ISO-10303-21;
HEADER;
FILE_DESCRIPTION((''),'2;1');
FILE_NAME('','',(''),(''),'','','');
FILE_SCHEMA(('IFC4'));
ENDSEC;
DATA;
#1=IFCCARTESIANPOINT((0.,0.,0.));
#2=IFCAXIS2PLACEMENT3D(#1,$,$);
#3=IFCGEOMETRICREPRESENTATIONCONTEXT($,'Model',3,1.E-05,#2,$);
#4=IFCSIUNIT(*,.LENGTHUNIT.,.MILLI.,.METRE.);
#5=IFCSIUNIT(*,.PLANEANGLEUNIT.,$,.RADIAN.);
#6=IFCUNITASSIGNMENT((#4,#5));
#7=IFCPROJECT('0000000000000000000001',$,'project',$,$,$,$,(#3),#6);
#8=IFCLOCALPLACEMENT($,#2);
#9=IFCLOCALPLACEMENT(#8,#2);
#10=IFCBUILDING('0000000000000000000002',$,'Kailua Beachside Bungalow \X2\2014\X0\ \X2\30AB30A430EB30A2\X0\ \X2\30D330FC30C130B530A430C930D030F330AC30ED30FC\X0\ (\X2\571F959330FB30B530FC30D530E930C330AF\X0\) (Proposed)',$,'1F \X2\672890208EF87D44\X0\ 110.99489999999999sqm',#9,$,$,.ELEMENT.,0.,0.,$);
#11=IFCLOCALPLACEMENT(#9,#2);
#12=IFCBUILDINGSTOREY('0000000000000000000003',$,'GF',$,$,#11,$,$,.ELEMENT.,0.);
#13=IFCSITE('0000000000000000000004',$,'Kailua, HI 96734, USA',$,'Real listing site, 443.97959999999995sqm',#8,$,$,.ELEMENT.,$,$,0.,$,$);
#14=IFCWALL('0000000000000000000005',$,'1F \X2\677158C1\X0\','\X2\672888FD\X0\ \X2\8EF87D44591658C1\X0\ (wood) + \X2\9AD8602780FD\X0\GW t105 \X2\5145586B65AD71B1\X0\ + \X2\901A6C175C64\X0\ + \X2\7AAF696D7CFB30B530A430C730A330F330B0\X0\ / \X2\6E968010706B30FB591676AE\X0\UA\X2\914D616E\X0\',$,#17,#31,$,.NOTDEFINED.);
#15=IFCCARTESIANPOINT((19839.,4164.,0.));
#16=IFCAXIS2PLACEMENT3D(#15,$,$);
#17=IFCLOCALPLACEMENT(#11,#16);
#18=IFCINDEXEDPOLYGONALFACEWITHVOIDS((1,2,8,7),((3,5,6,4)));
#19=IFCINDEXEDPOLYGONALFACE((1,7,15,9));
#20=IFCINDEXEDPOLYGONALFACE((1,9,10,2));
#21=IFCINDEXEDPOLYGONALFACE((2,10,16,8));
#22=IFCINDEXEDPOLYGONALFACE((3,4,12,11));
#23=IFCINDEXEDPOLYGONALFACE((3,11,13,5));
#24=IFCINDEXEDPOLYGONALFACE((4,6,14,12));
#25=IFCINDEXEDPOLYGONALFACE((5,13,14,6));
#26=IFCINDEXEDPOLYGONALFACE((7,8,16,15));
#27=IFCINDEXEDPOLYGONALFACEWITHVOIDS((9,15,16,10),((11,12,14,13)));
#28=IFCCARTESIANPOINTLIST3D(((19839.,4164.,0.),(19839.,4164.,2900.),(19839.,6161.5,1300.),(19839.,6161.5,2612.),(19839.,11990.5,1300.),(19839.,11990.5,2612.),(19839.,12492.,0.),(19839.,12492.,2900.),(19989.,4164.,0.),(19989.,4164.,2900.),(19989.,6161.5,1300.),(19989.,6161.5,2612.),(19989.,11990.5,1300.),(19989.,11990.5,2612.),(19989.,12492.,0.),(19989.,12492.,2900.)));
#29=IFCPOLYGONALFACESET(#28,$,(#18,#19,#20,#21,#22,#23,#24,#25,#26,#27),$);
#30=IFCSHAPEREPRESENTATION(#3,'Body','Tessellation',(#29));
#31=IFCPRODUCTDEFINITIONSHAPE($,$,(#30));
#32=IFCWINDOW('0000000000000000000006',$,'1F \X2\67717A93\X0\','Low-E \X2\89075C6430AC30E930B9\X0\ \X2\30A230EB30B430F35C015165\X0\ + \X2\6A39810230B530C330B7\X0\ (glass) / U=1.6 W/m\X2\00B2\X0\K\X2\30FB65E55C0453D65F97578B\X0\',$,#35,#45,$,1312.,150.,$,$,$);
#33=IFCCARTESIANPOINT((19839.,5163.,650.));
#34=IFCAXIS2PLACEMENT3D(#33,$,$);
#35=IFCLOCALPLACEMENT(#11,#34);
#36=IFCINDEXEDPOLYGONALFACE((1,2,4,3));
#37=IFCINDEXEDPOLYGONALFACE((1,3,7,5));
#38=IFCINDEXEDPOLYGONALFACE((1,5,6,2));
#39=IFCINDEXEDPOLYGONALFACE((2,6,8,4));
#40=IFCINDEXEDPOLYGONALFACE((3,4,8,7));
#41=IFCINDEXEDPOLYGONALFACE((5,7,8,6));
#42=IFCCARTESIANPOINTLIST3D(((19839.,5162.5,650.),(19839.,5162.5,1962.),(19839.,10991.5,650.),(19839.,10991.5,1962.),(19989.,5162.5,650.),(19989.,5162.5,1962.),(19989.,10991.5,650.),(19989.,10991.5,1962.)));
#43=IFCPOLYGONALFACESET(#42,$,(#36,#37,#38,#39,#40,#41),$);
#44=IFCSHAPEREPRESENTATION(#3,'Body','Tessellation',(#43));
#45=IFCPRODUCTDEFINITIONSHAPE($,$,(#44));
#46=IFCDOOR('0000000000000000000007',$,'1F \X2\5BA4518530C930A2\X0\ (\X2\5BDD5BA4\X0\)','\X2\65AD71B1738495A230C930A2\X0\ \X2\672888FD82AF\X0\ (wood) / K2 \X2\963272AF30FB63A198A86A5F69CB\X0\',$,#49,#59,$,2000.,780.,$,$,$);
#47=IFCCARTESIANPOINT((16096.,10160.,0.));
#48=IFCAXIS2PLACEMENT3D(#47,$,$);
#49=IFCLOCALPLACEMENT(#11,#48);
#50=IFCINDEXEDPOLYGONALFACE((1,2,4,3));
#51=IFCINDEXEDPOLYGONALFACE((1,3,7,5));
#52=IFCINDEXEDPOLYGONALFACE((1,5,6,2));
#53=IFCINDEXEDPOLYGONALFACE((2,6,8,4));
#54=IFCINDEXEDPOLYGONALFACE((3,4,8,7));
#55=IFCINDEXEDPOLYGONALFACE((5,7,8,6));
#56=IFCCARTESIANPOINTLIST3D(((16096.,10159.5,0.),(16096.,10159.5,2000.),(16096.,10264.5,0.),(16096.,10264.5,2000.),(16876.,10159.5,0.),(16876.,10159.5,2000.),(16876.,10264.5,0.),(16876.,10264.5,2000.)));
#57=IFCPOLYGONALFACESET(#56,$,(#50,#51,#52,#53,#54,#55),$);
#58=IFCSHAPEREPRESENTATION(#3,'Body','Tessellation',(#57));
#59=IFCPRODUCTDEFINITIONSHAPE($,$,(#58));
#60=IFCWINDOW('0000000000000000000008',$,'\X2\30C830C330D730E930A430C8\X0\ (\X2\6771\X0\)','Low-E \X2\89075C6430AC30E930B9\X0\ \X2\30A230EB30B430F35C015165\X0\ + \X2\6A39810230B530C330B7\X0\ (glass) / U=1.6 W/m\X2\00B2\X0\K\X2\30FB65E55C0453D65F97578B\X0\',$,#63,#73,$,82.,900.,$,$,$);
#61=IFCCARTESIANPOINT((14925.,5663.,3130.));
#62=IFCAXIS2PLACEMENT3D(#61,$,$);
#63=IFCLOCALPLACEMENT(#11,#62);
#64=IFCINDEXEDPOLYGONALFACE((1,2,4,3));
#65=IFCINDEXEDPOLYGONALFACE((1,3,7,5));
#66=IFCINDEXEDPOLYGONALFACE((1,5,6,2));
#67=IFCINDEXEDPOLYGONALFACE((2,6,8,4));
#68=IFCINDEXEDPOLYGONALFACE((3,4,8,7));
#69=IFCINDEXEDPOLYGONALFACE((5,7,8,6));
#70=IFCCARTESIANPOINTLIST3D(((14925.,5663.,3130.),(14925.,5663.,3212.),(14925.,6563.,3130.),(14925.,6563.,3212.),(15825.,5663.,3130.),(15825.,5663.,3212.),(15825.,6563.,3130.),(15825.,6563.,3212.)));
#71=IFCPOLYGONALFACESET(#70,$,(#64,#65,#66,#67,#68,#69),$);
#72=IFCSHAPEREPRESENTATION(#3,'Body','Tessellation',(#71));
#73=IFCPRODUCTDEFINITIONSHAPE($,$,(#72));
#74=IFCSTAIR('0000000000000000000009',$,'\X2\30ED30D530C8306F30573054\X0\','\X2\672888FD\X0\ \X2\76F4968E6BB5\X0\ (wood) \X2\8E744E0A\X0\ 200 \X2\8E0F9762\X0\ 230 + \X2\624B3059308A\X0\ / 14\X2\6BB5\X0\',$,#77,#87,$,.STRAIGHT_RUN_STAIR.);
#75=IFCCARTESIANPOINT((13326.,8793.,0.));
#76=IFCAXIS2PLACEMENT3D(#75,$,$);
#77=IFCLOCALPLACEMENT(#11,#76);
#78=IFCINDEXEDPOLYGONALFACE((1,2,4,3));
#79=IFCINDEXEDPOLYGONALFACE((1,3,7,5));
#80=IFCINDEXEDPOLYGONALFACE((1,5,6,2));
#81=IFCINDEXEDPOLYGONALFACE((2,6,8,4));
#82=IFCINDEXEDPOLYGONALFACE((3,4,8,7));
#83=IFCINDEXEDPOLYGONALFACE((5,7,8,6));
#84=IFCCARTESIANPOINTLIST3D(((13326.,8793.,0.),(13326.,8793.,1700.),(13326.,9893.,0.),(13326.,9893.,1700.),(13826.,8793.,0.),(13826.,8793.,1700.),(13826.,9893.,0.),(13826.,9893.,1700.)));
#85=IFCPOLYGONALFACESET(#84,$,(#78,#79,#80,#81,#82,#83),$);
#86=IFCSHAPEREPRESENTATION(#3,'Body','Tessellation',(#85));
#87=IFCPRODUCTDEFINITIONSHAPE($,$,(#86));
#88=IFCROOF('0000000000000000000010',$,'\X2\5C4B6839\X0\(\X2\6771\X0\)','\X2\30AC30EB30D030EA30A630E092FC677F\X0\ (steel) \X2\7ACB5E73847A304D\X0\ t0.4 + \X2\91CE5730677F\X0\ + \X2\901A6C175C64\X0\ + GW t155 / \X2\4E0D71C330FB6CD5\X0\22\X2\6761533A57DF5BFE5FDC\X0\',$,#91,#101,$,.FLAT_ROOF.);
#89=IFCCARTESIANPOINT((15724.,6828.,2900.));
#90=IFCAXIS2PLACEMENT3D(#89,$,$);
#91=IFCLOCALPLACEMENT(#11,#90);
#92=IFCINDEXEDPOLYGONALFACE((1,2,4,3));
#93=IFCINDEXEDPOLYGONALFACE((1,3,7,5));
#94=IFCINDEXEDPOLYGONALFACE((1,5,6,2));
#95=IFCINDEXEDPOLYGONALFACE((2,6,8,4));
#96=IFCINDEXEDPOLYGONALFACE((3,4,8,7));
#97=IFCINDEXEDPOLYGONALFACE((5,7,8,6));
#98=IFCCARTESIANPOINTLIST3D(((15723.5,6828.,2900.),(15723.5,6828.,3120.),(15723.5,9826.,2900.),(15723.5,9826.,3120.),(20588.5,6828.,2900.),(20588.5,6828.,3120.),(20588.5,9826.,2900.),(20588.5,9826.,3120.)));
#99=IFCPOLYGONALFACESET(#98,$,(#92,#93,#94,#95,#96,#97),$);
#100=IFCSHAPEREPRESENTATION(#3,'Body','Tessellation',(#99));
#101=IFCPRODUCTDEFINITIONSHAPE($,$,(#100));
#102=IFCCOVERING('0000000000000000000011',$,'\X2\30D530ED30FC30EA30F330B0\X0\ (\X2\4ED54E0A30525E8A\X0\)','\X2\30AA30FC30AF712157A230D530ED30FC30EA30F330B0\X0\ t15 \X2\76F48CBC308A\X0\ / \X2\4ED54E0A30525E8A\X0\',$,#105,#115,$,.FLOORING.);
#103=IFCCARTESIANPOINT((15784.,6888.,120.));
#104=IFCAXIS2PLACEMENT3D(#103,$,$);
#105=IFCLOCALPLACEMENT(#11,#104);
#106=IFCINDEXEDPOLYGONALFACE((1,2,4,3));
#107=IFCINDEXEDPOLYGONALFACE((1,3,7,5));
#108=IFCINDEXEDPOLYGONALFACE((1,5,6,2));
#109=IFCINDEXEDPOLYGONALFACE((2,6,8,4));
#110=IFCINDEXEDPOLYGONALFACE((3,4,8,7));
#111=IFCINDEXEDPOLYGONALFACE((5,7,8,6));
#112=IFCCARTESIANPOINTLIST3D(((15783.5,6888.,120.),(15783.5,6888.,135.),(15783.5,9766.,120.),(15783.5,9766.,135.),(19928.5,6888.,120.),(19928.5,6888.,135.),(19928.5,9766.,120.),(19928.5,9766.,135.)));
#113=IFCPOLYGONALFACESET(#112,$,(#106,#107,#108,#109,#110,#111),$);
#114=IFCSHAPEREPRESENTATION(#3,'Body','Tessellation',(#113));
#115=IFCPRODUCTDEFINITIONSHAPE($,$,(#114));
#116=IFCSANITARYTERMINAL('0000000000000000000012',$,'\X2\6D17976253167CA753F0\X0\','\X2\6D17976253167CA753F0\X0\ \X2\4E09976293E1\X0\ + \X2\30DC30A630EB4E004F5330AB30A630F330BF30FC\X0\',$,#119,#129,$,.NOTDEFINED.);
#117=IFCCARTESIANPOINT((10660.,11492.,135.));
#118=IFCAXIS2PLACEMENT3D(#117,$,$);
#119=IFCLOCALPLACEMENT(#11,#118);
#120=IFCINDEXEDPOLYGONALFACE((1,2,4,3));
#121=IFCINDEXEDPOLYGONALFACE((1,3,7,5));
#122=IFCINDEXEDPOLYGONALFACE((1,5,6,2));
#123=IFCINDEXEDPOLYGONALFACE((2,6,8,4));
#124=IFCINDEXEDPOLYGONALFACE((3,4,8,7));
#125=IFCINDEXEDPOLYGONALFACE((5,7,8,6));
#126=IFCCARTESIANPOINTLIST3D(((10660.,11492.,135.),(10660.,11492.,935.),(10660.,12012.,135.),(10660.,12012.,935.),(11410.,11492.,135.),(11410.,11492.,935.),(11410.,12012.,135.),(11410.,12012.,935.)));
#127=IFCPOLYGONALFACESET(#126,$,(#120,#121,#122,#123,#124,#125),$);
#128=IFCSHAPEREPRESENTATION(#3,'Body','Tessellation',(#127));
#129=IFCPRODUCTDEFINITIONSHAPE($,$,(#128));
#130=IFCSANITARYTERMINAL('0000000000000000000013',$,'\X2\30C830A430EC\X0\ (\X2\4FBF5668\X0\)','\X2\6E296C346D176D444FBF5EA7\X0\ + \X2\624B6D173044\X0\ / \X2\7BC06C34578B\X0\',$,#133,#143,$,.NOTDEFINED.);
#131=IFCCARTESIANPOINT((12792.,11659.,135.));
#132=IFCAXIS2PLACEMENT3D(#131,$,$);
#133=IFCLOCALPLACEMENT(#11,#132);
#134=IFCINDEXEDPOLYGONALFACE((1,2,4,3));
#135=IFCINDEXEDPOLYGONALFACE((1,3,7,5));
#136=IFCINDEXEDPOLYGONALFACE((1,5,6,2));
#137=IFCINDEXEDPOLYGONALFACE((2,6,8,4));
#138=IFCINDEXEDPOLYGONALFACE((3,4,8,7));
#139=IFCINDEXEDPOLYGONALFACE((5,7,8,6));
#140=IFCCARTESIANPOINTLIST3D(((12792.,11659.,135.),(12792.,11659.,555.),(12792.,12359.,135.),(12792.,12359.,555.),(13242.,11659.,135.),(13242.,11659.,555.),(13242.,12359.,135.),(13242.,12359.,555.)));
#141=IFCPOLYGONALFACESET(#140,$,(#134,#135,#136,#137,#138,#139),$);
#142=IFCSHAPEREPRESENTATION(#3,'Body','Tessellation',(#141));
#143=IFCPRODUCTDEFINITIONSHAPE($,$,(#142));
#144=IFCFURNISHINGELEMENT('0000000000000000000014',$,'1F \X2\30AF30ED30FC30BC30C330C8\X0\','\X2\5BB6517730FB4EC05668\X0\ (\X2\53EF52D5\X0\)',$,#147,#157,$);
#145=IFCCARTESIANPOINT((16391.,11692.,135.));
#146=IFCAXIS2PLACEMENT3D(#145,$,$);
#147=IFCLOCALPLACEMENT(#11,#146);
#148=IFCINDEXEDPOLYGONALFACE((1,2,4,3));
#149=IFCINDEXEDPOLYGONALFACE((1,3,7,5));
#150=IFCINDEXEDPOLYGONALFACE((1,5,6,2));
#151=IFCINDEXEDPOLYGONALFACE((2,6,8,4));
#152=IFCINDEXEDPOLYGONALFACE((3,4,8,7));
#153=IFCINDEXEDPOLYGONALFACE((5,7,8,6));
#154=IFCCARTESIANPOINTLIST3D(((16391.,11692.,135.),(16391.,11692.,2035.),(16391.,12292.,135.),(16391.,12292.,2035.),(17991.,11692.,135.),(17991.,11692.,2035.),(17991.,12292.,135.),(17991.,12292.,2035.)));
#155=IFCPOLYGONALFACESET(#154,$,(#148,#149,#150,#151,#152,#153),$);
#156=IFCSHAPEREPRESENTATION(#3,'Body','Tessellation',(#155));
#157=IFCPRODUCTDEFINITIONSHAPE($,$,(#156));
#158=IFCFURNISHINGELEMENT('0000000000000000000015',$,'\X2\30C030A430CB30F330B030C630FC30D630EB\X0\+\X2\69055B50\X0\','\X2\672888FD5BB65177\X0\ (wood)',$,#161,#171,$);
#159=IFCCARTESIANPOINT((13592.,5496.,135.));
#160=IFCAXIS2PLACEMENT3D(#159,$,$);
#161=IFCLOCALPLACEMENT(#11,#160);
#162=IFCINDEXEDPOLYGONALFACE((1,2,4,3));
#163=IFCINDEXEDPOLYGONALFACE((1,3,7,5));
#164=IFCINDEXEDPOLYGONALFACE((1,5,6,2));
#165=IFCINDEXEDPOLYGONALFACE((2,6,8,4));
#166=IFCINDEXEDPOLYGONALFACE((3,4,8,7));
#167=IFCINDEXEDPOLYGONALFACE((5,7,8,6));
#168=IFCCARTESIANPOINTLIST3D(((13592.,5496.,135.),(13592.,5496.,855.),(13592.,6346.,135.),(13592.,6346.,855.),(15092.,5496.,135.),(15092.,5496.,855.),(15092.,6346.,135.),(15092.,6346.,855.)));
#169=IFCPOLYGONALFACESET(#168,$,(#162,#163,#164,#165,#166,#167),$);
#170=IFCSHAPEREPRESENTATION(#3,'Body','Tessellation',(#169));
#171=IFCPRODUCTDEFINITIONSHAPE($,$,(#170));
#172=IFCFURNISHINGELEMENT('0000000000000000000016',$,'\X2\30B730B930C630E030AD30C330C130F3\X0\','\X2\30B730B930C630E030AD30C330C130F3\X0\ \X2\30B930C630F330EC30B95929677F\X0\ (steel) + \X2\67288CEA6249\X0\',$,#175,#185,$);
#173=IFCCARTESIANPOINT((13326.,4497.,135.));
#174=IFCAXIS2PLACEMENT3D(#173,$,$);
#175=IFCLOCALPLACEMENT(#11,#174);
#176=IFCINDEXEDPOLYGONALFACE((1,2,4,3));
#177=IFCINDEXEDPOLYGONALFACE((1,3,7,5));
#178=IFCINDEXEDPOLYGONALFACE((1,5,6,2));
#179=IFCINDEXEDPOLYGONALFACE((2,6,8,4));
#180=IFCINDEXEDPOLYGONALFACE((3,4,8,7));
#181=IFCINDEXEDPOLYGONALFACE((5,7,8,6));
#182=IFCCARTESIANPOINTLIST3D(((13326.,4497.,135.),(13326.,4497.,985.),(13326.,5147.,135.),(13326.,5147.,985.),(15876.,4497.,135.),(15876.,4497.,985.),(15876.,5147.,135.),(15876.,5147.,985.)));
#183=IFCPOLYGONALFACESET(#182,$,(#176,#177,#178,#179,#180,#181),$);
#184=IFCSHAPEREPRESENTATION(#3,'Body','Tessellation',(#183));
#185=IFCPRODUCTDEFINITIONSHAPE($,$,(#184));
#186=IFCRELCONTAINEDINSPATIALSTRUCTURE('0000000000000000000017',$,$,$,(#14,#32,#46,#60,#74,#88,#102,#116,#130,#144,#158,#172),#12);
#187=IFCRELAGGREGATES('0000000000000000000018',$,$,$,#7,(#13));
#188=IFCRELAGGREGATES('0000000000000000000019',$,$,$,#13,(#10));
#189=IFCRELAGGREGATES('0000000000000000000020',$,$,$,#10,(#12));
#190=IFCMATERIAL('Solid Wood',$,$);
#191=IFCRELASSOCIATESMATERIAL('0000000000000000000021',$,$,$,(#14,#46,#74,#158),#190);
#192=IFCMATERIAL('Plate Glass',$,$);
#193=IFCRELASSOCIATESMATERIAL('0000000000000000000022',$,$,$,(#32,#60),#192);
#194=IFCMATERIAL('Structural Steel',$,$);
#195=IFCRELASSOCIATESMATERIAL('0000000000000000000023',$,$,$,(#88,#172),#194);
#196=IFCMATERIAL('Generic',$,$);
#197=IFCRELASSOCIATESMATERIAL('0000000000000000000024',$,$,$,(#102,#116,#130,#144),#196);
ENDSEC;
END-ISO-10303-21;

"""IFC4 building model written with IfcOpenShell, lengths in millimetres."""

from ifc_helpers import new_model, si_unit, frame, frame_2d, origin, place, context, project, spatial, rectangle, extrude, material, element, fill, save


model = new_model("IFC4")

# Units and contexts
model_context = context("Model", 3, precision=1e-05, world=origin())
ifc_project = project(units=[si_unit("LENGTHUNIT", "METRE", prefix="MILLI"), si_unit("PLANEANGLEUNIT", "RADIAN")], contexts=[model_context])

# Site, building, storey
site_placement = place(None, origin())
site = spatial("IfcSite", under=ifc_project, at=site_placement, Name="Kailua, HI 96734, USA", ObjectType="Real listing site, 443.97959999999995sqm", CompositionType="ELEMENT", RefElevation=0.0)
building_placement = place(site_placement, origin())
building = spatial("IfcBuilding", under=site, at=building_placement, Name="Kailua Beachside Bungalow — カイルア ビーチサイドバンガロー (土間・サーフラック) (Proposed)", ObjectType="1F 木造軸組 110.99489999999999sqm", CompositionType="ELEMENT", ElevationOfRefHeight=0.0, ElevationOfTerrain=0.0)
storey_placement = place(building_placement, origin())
storey = spatial("IfcBuildingStorey", under=building, at=storey_placement, Name="GF", CompositionType="ELEMENT", Elevation=0.0)

# Shared definitions
ifc_material_1 = material(Name="Solid Wood")

# Wall, opening, window
wall_1_placement = place(storey_placement, frame((19839.0, 4164.0, 0.0)))
wall_1 = element("IfcWall", 1, at=wall_1_placement, inside=storey, material=ifc_material_1, Name="1F 東壁", Description="木製 軸組外壁 (wood) + 高性能GW t105 充填断熱 + 通気層 + 窯業系サイディング / 準耐火・外皮UA配慮", PredefinedType="NOTDEFINED", context=model_context, shape_type="SweptSolid", body=[
    extrude(rectangle(XDim=150.0, YDim=8328.0, at=frame_2d((75.0, 4164.0))), frame((19839.0, 4164.0, 0.0)), (0.0, 0.0, 1.0), 2900.0),
])
opening_1_placement = place(storey_placement, frame((19839.0, 5163.0, 650.0)))
opening_1 = element("IfcOpeningElement", 2, at=opening_1_placement, cuts=wall_1, PredefinedType="NOTDEFINED", context=model_context, shape_type="SweptSolid", body=[
    extrude(rectangle(XDim=150.0, YDim=5829.0, at=frame_2d((75.0, 2914.0))), frame((19839.0, 5163.0, 650.0)), (0.0, 0.0, 1.0), 1312.0),
])
ifc_material_2 = material(Name="Plate Glass")
window_1_placement = place(storey_placement, frame((19839.0, 5163.0, 650.0)))
window_1 = element("IfcWindow", 3, at=window_1_placement, inside=storey, material=ifc_material_2, Name="1F 東窓", Description="Low-E 複層ガラス アルゴン封入 + 樹脂サッシ (glass) / U=1.6 W/m²K・日射取得型", OverallHeight=1312.0, OverallWidth=150.0, context=model_context, shape_type="SweptSolid", body=[
    extrude(rectangle(XDim=150.0, YDim=5829.0, at=frame_2d((75.0, 2914.0))), frame((19839.0, 5163.0, 650.0)), (0.0, 0.0, 1.0), 1312.0),
])
fill(opening_1, window_1)

# Door
door_placement = place(storey_placement, frame((16096.0, 10160.0, 0.0)))
element("IfcDoor", 4, at=door_placement, inside=storey, material=ifc_material_1, Name="1F 室内ドア (寝室)", Description="断熱玄関ドア 木製芯 (wood) / K2 防犯・採風機構", OverallHeight=2000.0, OverallWidth=780.0, context=model_context, shape_type="SweptSolid", body=[
    extrude(rectangle(XDim=780.0, YDim=105.0, at=frame_2d((390.0, 52.0))), frame((16096.0, 10160.0, 0.0)), (0.0, 0.0, 1.0), 2000.0),
])

# Window
window_2_placement = place(storey_placement, frame((14925.0, 5663.0, 3130.0)))
element("IfcWindow", 5, at=window_2_placement, inside=storey, material=ifc_material_2, Name="トップライト (東)", Description="Low-E 複層ガラス アルゴン封入 + 樹脂サッシ (glass) / U=1.6 W/m²K・日射取得型", OverallHeight=82.0, OverallWidth=900.0, context=model_context, shape_type="SweptSolid", body=[
    extrude(rectangle(XDim=900.0, YDim=900.0, at=frame_2d((450.0, 450.0))), frame((14925.0, 5663.0, 3130.0)), (0.0, 0.0, 1.0), 82.0),
])

# Stair
stair_placement = place(storey_placement, frame((13326.0, 8793.0, 0.0)))
element("IfcStair", 6, at=stair_placement, inside=storey, material=ifc_material_1, Name="ロフトはしご", Description="木製 直階段 (wood) 蹴上 200 踏面 230 + 手すり / 14段", PredefinedType="STRAIGHT_RUN_STAIR", context=model_context, shape_type="SweptSolid", body=[
    extrude(rectangle(XDim=500.0, YDim=1100.0, at=frame_2d((250.0, 550.0))), frame((13326.0, 8793.0, 0.0)), (0.0, 0.0, 1.0), 1700.0),
])

# Roof
ifc_material_3 = material(Name="Structural Steel")
roof_placement = place(storey_placement, frame((15724.0, 6828.0, 2900.0)))
element("IfcRoof", 7, at=roof_placement, inside=storey, material=ifc_material_3, Name="屋根(東)", Description="ガルバリウム鋼板 (steel) 立平葺き t0.4 + 野地板 + 通気層 + GW t155 / 不燃・法22条区域対応", PredefinedType="FLAT_ROOF", context=model_context, shape_type="SweptSolid", body=[
    extrude(rectangle(XDim=4865.0, YDim=2998.0, at=frame_2d((2432.0, 1499.0))), frame((15724.0, 6828.0, 2900.0)), (0.0, 0.0, 1.0), 220.0),
])

# Covering
ifc_material_4 = material(Name="Generic")
covering_placement = place(storey_placement, frame((15784.0, 6888.0, 120.0)))
element("IfcCovering", 8, at=covering_placement, inside=storey, material=ifc_material_4, Name="フローリング (仕上げ床)", Description="オーク無垢フローリング t15 直貼り / 仕上げ床", PredefinedType="FLOORING", context=model_context, shape_type="SweptSolid", body=[
    extrude(rectangle(XDim=4145.0, YDim=2878.0, at=frame_2d((2072.0, 1439.0))), frame((15784.0, 6888.0, 120.0)), (0.0, 0.0, 1.0), 15.0),
])

# Sanitary terminals
sanitary_terminal_1_placement = place(storey_placement, frame((10660.0, 11492.0, 135.0)))
element("IfcSanitaryTerminal", 9, at=sanitary_terminal_1_placement, inside=storey, material=ifc_material_4, Name="洗面化粧台", Description="洗面化粧台 三面鏡 + ボウル一体カウンター", PredefinedType="NOTDEFINED", context=model_context, shape_type="SweptSolid", body=[
    extrude(rectangle(XDim=750.0, YDim=520.0, at=frame_2d((375.0, 260.0))), frame((10660.0, 11492.0, 135.0)), (0.0, 0.0, 1.0), 800.0),
])
sanitary_terminal_2_placement = place(storey_placement, frame((12792.0, 11659.0, 135.0)))
element("IfcSanitaryTerminal", 10, at=sanitary_terminal_2_placement, inside=storey, material=ifc_material_4, Name="トイレ (便器)", Description="温水洗浄便座 + 手洗い / 節水型", PredefinedType="NOTDEFINED", context=model_context, shape_type="SweptSolid", body=[
    extrude(rectangle(XDim=450.0, YDim=700.0, at=frame_2d((225.0, 350.0))), frame((12792.0, 11659.0, 135.0)), (0.0, 0.0, 1.0), 420.0),
])

# Furnishing elements
furnishing_1_placement = place(storey_placement, frame((16391.0, 11692.0, 135.0)))
element("IfcFurnishingElement", 11, at=furnishing_1_placement, inside=storey, material=ifc_material_4, Name="1F クローゼット", Description="家具・什器 (可動)", context=model_context, shape_type="SweptSolid", body=[
    extrude(rectangle(XDim=1600.0, YDim=600.0, at=frame_2d((800.0, 300.0))), frame((16391.0, 11692.0, 135.0)), (0.0, 0.0, 1.0), 1900.0),
])
furnishing_2_placement = place(storey_placement, frame((13592.0, 5496.0, 135.0)))
element("IfcFurnishingElement", 12, at=furnishing_2_placement, inside=storey, material=ifc_material_1, Name="ダイニングテーブル+椅子", Description="木製家具 (wood)", context=model_context, shape_type="SweptSolid", body=[
    extrude(rectangle(XDim=1500.0, YDim=850.0, at=frame_2d((750.0, 425.0))), frame((13592.0, 5496.0, 135.0)), (0.0, 0.0, 1.0), 720.0),
])
furnishing_3_placement = place(storey_placement, frame((13326.0, 4497.0, 135.0)))
element("IfcFurnishingElement", 13, at=furnishing_3_placement, inside=storey, material=ifc_material_3, Name="システムキッチン", Description="システムキッチン ステンレス天板 (steel) + 木質扉", context=model_context, shape_type="SweptSolid", body=[
    extrude(rectangle(XDim=2550.0, YDim=650.0, at=frame_2d((1275.0, 325.0))), frame((13326.0, 4497.0, 135.0)), (0.0, 0.0, 1.0), 850.0),
])

save(model, "model.ifc")
